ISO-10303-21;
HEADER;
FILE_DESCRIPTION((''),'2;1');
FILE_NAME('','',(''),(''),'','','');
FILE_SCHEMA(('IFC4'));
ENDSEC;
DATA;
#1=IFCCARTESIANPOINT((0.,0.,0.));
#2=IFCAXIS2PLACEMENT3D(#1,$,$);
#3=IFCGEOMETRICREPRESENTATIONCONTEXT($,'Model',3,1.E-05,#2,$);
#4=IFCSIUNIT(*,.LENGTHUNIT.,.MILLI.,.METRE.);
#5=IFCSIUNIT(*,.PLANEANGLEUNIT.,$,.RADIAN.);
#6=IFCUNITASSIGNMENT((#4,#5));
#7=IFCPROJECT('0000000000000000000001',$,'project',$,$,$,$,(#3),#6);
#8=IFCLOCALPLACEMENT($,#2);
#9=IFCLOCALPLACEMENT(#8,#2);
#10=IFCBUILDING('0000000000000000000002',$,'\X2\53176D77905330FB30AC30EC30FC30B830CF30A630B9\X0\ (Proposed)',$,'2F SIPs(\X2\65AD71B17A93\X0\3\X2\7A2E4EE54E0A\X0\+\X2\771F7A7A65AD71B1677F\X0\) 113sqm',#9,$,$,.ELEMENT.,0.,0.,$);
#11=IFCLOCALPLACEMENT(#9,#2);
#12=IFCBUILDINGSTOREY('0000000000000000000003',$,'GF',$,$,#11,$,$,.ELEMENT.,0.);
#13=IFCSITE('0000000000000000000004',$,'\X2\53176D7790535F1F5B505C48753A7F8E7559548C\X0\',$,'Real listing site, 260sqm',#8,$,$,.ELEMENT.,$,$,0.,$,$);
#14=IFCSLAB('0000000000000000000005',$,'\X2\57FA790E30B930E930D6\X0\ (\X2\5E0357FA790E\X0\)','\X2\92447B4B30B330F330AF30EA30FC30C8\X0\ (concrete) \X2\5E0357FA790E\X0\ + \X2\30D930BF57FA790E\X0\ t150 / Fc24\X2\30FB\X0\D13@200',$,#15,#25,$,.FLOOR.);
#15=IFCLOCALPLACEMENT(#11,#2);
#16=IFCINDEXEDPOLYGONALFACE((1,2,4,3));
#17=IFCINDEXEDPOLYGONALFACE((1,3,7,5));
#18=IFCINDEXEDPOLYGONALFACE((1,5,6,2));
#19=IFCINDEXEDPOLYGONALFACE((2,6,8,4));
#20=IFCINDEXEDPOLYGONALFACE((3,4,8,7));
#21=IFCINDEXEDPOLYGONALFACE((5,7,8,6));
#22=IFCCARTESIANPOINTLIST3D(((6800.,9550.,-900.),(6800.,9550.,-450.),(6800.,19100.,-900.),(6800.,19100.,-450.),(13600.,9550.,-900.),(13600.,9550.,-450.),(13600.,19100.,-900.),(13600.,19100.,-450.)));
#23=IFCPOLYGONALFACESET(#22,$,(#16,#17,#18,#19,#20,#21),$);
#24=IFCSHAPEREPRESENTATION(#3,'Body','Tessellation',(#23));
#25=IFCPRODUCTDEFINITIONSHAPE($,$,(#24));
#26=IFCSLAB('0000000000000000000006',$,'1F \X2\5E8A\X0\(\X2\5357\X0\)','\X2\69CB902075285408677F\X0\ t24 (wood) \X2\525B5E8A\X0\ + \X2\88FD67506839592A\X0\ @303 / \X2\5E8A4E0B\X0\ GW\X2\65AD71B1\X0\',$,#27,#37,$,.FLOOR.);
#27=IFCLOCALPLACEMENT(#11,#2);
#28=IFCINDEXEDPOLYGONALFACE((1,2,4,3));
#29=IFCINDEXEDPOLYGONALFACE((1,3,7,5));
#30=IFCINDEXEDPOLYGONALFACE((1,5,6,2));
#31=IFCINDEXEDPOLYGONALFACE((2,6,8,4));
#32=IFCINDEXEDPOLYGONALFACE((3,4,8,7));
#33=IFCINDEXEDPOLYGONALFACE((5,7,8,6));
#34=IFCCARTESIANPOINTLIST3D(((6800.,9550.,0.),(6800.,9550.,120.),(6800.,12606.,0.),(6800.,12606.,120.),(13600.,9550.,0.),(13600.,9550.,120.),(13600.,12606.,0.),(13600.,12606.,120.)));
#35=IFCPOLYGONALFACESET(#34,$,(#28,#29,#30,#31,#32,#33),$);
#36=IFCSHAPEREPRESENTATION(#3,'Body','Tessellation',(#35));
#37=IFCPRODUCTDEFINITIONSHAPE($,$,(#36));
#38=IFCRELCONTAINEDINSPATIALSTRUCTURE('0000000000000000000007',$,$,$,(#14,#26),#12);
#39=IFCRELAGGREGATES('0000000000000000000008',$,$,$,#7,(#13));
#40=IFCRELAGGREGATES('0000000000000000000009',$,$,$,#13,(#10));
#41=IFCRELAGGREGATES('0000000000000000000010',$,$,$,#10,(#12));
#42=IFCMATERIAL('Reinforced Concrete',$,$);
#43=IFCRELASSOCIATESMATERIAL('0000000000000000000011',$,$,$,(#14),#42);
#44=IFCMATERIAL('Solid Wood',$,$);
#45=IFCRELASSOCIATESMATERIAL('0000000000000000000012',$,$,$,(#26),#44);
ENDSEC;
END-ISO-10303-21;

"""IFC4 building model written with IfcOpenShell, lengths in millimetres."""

from ifc_helpers import new_model, si_unit, frame, frame_2d, origin, place, context, project, spatial, rectangle, extrude, material, element, save


model = new_model("IFC4")

# Units and contexts
model_context = context("Model", 3, precision=1e-05, world=origin())
ifc_project = project(units=[si_unit("LENGTHUNIT", "METRE", prefix="MILLI"), si_unit("PLANEANGLEUNIT", "RADIAN")], contexts=[model_context])

# Site, building, storey
site_placement = place(None, origin())
site = spatial("IfcSite", under=ifc_project, at=site_placement, Name="北海道弟子屈町美留和", ObjectType="Real listing site, 260sqm", CompositionType="ELEMENT", RefElevation=0.0)
building_placement = place(site_placement, origin())
building = spatial("IfcBuilding", under=site, at=building_placement, Name="北海道・ガレージハウス (Proposed)", ObjectType="2F SIPs(断熱窓3種以上+真空断熱板) 113sqm", CompositionType="ELEMENT", ElevationOfRefHeight=0.0, ElevationOfTerrain=0.0)
storey_placement = place(building_placement, origin())
storey = spatial("IfcBuildingStorey", under=building, at=storey_placement, Name="GF", CompositionType="ELEMENT", Elevation=0.0)

# Shared definitions
ifc_material_1 = material(Name="Solid Wood")

# Slabs
ifc_material_2 = material(Name="Reinforced Concrete")
slab_1_placement = place(storey_placement, frame((3400.0, 4775.0, -450.0)))
element("IfcSlab", 1, at=slab_1_placement, inside=storey, material=ifc_material_2, Name="基礎スラブ (布基礎)", Description="鉄筋コンクリート (concrete) 布基礎 + ベタ基礎 t150 / Fc24・D13@200", PredefinedType="FLOOR", context=model_context, shape_type="SweptSolid", body=[
    extrude(rectangle(XDim=6800.0, YDim=9550.0, at=frame_2d((3400.0, 4775.0))), frame((3400.0, 4775.0, -450.0)), (0.0, 0.0, 1.0), 450.0),
])
slab_2_placement = place(storey_placement, frame((3400.0, 4775.0, 0.0)))
element("IfcSlab", 2, at=slab_2_placement, inside=storey, material=ifc_material_1, Name="1F 床(南)", Description="構造用合板 t24 (wood) 剛床 + 製材根太 @303 / 床下 GW断熱", PredefinedType="FLOOR", context=model_context, shape_type="SweptSolid", body=[
    extrude(rectangle(XDim=6800.0, YDim=3056.0, at=frame_2d((3400.0, 1528.0))), frame((3400.0, 4775.0, 0.0)), (0.0, 0.0, 1.0), 120.0),
])

save(model, "model.ifc")
